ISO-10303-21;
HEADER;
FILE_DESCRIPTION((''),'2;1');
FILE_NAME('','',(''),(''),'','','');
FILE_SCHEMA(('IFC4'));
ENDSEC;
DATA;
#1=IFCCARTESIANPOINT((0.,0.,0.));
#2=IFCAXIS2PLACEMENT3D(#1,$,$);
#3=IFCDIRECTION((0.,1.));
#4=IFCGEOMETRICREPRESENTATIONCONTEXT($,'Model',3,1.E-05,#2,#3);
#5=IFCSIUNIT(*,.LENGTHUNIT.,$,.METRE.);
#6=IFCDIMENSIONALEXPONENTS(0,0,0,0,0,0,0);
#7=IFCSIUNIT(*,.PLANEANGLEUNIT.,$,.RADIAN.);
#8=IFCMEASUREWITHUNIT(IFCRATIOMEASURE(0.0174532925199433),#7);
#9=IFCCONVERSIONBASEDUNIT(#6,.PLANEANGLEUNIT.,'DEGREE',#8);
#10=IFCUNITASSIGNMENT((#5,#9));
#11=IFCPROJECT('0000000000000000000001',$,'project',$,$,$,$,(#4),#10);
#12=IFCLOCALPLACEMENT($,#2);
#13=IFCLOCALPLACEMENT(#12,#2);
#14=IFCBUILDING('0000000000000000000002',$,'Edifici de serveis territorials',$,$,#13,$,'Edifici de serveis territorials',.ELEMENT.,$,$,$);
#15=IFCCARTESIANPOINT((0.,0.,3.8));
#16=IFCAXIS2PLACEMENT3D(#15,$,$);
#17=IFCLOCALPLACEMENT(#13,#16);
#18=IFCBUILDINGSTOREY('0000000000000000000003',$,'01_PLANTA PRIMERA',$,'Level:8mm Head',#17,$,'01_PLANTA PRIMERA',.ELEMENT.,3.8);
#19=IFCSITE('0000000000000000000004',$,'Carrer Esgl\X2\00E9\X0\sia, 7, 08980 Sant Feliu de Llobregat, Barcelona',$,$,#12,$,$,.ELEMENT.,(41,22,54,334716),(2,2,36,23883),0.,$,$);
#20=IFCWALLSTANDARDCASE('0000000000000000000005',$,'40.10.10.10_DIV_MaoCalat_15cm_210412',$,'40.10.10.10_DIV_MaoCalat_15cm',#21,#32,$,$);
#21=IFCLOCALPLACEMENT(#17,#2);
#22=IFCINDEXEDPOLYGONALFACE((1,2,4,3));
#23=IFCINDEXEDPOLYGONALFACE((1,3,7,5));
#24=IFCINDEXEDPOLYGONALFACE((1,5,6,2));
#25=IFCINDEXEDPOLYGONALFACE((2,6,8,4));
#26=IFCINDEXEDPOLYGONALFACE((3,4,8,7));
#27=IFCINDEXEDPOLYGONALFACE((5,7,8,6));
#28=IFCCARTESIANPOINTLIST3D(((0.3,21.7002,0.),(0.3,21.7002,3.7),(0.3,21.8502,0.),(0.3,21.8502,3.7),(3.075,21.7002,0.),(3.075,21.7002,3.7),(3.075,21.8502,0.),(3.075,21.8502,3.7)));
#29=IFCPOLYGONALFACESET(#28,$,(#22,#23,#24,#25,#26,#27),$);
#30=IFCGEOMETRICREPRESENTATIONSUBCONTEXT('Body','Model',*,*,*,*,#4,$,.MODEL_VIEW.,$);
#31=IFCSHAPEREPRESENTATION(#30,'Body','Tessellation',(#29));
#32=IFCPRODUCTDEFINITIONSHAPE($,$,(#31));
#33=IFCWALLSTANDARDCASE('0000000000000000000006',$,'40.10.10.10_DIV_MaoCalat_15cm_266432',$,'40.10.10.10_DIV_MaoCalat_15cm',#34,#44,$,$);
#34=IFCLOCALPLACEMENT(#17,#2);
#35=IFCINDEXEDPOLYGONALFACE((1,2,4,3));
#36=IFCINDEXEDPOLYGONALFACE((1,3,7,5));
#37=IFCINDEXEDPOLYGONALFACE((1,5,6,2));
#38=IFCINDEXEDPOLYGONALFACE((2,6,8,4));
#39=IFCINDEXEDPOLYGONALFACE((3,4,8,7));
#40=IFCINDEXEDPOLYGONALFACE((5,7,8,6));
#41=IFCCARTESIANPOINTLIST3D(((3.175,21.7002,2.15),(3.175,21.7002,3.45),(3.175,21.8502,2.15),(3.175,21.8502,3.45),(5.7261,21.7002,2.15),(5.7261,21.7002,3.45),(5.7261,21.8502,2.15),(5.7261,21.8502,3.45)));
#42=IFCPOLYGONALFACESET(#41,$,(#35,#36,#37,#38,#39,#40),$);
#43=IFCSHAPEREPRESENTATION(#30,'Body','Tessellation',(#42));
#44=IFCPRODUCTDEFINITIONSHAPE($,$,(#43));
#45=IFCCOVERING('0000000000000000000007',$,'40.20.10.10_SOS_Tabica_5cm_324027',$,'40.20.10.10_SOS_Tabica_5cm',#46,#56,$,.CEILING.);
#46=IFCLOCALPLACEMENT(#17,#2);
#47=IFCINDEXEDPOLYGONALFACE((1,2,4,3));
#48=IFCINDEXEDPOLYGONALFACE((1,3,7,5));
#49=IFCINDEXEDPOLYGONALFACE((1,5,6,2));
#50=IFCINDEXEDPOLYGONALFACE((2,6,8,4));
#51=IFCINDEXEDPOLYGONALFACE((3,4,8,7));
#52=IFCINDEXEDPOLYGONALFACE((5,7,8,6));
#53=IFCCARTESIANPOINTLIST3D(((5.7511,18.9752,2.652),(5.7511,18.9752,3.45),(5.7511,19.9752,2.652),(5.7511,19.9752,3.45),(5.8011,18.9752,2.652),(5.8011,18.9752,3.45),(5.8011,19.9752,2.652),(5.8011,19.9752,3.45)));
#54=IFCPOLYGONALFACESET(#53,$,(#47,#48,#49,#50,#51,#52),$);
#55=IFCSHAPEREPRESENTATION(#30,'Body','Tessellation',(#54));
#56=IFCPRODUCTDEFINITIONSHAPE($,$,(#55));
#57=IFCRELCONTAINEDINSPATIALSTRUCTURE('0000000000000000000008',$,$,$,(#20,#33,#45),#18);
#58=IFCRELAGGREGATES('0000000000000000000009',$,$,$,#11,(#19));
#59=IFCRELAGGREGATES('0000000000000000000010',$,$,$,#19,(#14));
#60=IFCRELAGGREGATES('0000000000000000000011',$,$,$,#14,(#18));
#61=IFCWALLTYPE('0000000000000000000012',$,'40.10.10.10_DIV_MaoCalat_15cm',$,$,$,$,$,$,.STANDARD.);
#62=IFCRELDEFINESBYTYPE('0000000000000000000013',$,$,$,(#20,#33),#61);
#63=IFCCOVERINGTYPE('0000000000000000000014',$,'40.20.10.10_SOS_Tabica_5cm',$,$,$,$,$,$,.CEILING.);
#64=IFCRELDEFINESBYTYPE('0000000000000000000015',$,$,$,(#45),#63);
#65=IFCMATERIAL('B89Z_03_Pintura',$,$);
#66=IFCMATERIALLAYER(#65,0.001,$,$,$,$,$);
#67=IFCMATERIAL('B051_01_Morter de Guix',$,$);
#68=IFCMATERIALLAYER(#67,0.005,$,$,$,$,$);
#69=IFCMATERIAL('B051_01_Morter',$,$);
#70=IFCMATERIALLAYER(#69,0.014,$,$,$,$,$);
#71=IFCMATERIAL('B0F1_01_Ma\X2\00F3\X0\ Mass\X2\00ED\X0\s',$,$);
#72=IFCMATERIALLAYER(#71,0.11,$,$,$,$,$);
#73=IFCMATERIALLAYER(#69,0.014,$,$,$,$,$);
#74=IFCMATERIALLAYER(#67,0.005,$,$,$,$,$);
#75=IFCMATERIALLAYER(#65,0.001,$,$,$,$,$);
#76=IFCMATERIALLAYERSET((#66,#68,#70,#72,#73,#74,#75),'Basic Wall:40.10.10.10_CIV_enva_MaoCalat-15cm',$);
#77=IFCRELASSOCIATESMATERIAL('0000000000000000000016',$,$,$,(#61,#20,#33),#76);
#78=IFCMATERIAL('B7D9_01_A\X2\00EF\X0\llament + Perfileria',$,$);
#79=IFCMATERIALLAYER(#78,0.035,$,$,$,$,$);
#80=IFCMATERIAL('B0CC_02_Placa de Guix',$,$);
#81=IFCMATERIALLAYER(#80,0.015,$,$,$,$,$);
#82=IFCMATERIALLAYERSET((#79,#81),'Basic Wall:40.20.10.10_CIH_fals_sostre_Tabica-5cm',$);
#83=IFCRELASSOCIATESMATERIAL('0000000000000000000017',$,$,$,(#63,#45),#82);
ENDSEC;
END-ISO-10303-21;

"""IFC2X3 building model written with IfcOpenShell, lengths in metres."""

from ifc_helpers import new_model, entity, si_unit, converted_unit, direction, frame, frame_2d, origin, place, context, subcontext, project, spatial, polyline, rectangle, extrude, clip, bounded_halfspace, material, layer, layer_set, layer_usage, type_object, element, save


model = new_model("IFC2X3")

# Units and contexts
model_context = context("Model", 3, precision=1e-05, world=origin(), true_north=direction((0.0, 1.0)))
body_context = subcontext(model_context, "Body", "Model", "MODEL_VIEW")
ifc_project = project(units=[si_unit("LENGTHUNIT", "METRE"), converted_unit("PLANEANGLEUNIT", "DEGREE", entity("IfcRatioMeasure", 0.0174532925199433), si_unit("PLANEANGLEUNIT", "RADIAN"), dimensions=[0, 0, 0, 0, 0, 0, 0])], contexts=[model_context])

# Site, building, storey
site_placement = place(None, origin())
site = spatial("IfcSite", under=ifc_project, at=site_placement, Name="Carrer Església, 7, 08980 Sant Feliu de Llobregat, Barcelona", CompositionType="ELEMENT", RefLatitude=(41, 22, 54, 334716), RefLongitude=(2, 2, 36, 23883), RefElevation=0.0)
building_placement = place(site_placement, origin())
building = spatial("IfcBuilding", under=site, at=building_placement, Name="Edifici de serveis territorials", LongName="Edifici de serveis territorials", CompositionType="ELEMENT")
storey_placement = place(building_placement, frame((0.0, 0.0, 3.8)))
storey = spatial("IfcBuildingStorey", under=building, at=storey_placement, Name="01_PLANTA PRIMERA", ObjectType="Level:8mm Head", LongName="01_PLANTA PRIMERA", CompositionType="ELEMENT", Elevation=3.8)

# Shared definitions
ifc_material_1 = material(Name="B051_01_Morter")

# Shared definitions
ifc_material_2 = material(Name="B89Z_03_Pintura")
ifc_material_3 = material(Name="B0CC_02_Placa de Guix")
ifc_material_4 = material(Name="B7D9_01_Aïllament + Perfileria")

# Walls
ifc_layer_1 = layer(ifc_material_2, 0.001)
ifc_material_5 = material(Name="B051_01_Morter de Guix")
ifc_layer_2 = layer(ifc_material_5, 0.005)
ifc_layer_3 = layer(ifc_material_1, 0.014)
ifc_material_6 = material(Name="B0F1_01_Maó Massís")
ifc_layer_4 = layer(ifc_material_6, 0.11)
ifc_layer_5 = layer(ifc_material_1, 0.014)
ifc_layer_6 = layer(ifc_material_5, 0.005)
ifc_layer_7 = layer(ifc_material_2, 0.001)
ifc_layer_set_1 = layer_set([ifc_layer_1, ifc_layer_2, ifc_layer_3, ifc_layer_4, ifc_layer_5, ifc_layer_6, ifc_layer_7], Name="Basic Wall:40.10.10.10_CIV_enva_MaoCalat-15cm")
ifc_layer_usage_1 = layer_usage(ifc_layer_set_1, "AXIS2", "NEGATIVE", 0.075)
wall_type_1 = type_object("IfcWallType", Name="40.10.10.10_DIV_MaoCalat_15cm", PredefinedType="STANDARD", material=ifc_layer_set_1)
wall_1_placement = place(storey_placement, frame((3.075, 21.7752, 0.0), z_axis=(0.0, 0.0, 1.0), x_axis=(-1.0, 0.0, 0.0)))
element("IfcWallStandardCase", 1, at=wall_1_placement, inside=storey, type_object=wall_type_1, material=ifc_layer_usage_1, Name="40.10.10.10_DIV_MaoCalat_15cm_210412", ObjectType="40.10.10.10_DIV_MaoCalat_15cm", context=body_context, shape_type="Clipping", body=[
    clip(extrude(rectangle(XDim=2.775, YDim=0.15, at=frame_2d((1.3875, 0.0), x_axis=(-1.0, 0.0))), origin(), (0.0, 0.0, 1.0), 3.7), bounded_halfspace(frame((0.0, -0.075, 3.7), z_axis=(0.0, 0.0, -1.0), x_axis=(0.0, -1.0, 0.0)), True, frame((0.0, -0.075, 3.7)), polyline([(0.0, 0.0), (2.775, 0.0), (2.775, 0.15), (0.0, 0.15), (0.0, 0.0)]))),
])
ifc_layer_usage_2 = layer_usage(ifc_layer_set_1, "AXIS2", "NEGATIVE", 0.075)
wall_2_placement = place(storey_placement, frame((5.7261, 21.7752, 2.15), z_axis=(0.0, 0.0, 1.0), x_axis=(-1.0, 0.0, 0.0)))
element("IfcWallStandardCase", 2, at=wall_2_placement, inside=storey, type_object=wall_type_1, material=ifc_layer_usage_2, Name="40.10.10.10_DIV_MaoCalat_15cm_266432", ObjectType="40.10.10.10_DIV_MaoCalat_15cm", context=body_context, shape_type="Clipping", body=[
    clip(extrude(rectangle(XDim=2.5511, YDim=0.15, at=frame_2d((1.2755, 0.0), x_axis=(-1.0, 0.0))), origin(), (0.0, 0.0, 1.0), 1.3), bounded_halfspace(frame((0.0, -0.075, 1.3), z_axis=(0.0, 0.0, -1.0), x_axis=(-0.025497, 0.999675, 0.0)), True, frame((0.0, -0.075, 1.3)), polyline([(0.0, 0.0), (2.5511, 0.0), (2.5511, 0.15), (0.0, 0.15), (0.0, 0.0)]))),
])

# Covering
ifc_layer_8 = layer(ifc_material_4, 0.035)
ifc_layer_9 = layer(ifc_material_3, 0.015)
ifc_layer_set_2 = layer_set([ifc_layer_8, ifc_layer_9], Name="Basic Wall:40.20.10.10_CIH_fals_sostre_Tabica-5cm")
ifc_layer_usage_3 = layer_usage(ifc_layer_set_2, "AXIS2", "POSITIVE", -0.025)
covering_type = type_object("IfcCoveringType", Name="40.20.10.10_SOS_Tabica_5cm", PredefinedType="CEILING", material=ifc_layer_set_2)
covering_placement = place(storey_placement, frame((5.7761, 19.9752, 2.652), z_axis=(0.0, 0.0, 1.0), x_axis=(0.0, -1.0, 0.0)))
element("IfcCovering", 3, at=covering_placement, inside=storey, type_object=covering_type, material=ifc_layer_usage_3, Name="40.20.10.10_SOS_Tabica_5cm_324027", ObjectType="40.20.10.10_SOS_Tabica_5cm", PredefinedType="CEILING", context=body_context, shape_type="SweptSolid", body=[
    extrude(rectangle(XDim=1.0, YDim=0.05, at=frame_2d((0.5, 0.0), x_axis=(-1.0, 0.0))), origin(), (0.0, 0.0, 1.0), 0.798),
])

save(model, "model.ifc")
